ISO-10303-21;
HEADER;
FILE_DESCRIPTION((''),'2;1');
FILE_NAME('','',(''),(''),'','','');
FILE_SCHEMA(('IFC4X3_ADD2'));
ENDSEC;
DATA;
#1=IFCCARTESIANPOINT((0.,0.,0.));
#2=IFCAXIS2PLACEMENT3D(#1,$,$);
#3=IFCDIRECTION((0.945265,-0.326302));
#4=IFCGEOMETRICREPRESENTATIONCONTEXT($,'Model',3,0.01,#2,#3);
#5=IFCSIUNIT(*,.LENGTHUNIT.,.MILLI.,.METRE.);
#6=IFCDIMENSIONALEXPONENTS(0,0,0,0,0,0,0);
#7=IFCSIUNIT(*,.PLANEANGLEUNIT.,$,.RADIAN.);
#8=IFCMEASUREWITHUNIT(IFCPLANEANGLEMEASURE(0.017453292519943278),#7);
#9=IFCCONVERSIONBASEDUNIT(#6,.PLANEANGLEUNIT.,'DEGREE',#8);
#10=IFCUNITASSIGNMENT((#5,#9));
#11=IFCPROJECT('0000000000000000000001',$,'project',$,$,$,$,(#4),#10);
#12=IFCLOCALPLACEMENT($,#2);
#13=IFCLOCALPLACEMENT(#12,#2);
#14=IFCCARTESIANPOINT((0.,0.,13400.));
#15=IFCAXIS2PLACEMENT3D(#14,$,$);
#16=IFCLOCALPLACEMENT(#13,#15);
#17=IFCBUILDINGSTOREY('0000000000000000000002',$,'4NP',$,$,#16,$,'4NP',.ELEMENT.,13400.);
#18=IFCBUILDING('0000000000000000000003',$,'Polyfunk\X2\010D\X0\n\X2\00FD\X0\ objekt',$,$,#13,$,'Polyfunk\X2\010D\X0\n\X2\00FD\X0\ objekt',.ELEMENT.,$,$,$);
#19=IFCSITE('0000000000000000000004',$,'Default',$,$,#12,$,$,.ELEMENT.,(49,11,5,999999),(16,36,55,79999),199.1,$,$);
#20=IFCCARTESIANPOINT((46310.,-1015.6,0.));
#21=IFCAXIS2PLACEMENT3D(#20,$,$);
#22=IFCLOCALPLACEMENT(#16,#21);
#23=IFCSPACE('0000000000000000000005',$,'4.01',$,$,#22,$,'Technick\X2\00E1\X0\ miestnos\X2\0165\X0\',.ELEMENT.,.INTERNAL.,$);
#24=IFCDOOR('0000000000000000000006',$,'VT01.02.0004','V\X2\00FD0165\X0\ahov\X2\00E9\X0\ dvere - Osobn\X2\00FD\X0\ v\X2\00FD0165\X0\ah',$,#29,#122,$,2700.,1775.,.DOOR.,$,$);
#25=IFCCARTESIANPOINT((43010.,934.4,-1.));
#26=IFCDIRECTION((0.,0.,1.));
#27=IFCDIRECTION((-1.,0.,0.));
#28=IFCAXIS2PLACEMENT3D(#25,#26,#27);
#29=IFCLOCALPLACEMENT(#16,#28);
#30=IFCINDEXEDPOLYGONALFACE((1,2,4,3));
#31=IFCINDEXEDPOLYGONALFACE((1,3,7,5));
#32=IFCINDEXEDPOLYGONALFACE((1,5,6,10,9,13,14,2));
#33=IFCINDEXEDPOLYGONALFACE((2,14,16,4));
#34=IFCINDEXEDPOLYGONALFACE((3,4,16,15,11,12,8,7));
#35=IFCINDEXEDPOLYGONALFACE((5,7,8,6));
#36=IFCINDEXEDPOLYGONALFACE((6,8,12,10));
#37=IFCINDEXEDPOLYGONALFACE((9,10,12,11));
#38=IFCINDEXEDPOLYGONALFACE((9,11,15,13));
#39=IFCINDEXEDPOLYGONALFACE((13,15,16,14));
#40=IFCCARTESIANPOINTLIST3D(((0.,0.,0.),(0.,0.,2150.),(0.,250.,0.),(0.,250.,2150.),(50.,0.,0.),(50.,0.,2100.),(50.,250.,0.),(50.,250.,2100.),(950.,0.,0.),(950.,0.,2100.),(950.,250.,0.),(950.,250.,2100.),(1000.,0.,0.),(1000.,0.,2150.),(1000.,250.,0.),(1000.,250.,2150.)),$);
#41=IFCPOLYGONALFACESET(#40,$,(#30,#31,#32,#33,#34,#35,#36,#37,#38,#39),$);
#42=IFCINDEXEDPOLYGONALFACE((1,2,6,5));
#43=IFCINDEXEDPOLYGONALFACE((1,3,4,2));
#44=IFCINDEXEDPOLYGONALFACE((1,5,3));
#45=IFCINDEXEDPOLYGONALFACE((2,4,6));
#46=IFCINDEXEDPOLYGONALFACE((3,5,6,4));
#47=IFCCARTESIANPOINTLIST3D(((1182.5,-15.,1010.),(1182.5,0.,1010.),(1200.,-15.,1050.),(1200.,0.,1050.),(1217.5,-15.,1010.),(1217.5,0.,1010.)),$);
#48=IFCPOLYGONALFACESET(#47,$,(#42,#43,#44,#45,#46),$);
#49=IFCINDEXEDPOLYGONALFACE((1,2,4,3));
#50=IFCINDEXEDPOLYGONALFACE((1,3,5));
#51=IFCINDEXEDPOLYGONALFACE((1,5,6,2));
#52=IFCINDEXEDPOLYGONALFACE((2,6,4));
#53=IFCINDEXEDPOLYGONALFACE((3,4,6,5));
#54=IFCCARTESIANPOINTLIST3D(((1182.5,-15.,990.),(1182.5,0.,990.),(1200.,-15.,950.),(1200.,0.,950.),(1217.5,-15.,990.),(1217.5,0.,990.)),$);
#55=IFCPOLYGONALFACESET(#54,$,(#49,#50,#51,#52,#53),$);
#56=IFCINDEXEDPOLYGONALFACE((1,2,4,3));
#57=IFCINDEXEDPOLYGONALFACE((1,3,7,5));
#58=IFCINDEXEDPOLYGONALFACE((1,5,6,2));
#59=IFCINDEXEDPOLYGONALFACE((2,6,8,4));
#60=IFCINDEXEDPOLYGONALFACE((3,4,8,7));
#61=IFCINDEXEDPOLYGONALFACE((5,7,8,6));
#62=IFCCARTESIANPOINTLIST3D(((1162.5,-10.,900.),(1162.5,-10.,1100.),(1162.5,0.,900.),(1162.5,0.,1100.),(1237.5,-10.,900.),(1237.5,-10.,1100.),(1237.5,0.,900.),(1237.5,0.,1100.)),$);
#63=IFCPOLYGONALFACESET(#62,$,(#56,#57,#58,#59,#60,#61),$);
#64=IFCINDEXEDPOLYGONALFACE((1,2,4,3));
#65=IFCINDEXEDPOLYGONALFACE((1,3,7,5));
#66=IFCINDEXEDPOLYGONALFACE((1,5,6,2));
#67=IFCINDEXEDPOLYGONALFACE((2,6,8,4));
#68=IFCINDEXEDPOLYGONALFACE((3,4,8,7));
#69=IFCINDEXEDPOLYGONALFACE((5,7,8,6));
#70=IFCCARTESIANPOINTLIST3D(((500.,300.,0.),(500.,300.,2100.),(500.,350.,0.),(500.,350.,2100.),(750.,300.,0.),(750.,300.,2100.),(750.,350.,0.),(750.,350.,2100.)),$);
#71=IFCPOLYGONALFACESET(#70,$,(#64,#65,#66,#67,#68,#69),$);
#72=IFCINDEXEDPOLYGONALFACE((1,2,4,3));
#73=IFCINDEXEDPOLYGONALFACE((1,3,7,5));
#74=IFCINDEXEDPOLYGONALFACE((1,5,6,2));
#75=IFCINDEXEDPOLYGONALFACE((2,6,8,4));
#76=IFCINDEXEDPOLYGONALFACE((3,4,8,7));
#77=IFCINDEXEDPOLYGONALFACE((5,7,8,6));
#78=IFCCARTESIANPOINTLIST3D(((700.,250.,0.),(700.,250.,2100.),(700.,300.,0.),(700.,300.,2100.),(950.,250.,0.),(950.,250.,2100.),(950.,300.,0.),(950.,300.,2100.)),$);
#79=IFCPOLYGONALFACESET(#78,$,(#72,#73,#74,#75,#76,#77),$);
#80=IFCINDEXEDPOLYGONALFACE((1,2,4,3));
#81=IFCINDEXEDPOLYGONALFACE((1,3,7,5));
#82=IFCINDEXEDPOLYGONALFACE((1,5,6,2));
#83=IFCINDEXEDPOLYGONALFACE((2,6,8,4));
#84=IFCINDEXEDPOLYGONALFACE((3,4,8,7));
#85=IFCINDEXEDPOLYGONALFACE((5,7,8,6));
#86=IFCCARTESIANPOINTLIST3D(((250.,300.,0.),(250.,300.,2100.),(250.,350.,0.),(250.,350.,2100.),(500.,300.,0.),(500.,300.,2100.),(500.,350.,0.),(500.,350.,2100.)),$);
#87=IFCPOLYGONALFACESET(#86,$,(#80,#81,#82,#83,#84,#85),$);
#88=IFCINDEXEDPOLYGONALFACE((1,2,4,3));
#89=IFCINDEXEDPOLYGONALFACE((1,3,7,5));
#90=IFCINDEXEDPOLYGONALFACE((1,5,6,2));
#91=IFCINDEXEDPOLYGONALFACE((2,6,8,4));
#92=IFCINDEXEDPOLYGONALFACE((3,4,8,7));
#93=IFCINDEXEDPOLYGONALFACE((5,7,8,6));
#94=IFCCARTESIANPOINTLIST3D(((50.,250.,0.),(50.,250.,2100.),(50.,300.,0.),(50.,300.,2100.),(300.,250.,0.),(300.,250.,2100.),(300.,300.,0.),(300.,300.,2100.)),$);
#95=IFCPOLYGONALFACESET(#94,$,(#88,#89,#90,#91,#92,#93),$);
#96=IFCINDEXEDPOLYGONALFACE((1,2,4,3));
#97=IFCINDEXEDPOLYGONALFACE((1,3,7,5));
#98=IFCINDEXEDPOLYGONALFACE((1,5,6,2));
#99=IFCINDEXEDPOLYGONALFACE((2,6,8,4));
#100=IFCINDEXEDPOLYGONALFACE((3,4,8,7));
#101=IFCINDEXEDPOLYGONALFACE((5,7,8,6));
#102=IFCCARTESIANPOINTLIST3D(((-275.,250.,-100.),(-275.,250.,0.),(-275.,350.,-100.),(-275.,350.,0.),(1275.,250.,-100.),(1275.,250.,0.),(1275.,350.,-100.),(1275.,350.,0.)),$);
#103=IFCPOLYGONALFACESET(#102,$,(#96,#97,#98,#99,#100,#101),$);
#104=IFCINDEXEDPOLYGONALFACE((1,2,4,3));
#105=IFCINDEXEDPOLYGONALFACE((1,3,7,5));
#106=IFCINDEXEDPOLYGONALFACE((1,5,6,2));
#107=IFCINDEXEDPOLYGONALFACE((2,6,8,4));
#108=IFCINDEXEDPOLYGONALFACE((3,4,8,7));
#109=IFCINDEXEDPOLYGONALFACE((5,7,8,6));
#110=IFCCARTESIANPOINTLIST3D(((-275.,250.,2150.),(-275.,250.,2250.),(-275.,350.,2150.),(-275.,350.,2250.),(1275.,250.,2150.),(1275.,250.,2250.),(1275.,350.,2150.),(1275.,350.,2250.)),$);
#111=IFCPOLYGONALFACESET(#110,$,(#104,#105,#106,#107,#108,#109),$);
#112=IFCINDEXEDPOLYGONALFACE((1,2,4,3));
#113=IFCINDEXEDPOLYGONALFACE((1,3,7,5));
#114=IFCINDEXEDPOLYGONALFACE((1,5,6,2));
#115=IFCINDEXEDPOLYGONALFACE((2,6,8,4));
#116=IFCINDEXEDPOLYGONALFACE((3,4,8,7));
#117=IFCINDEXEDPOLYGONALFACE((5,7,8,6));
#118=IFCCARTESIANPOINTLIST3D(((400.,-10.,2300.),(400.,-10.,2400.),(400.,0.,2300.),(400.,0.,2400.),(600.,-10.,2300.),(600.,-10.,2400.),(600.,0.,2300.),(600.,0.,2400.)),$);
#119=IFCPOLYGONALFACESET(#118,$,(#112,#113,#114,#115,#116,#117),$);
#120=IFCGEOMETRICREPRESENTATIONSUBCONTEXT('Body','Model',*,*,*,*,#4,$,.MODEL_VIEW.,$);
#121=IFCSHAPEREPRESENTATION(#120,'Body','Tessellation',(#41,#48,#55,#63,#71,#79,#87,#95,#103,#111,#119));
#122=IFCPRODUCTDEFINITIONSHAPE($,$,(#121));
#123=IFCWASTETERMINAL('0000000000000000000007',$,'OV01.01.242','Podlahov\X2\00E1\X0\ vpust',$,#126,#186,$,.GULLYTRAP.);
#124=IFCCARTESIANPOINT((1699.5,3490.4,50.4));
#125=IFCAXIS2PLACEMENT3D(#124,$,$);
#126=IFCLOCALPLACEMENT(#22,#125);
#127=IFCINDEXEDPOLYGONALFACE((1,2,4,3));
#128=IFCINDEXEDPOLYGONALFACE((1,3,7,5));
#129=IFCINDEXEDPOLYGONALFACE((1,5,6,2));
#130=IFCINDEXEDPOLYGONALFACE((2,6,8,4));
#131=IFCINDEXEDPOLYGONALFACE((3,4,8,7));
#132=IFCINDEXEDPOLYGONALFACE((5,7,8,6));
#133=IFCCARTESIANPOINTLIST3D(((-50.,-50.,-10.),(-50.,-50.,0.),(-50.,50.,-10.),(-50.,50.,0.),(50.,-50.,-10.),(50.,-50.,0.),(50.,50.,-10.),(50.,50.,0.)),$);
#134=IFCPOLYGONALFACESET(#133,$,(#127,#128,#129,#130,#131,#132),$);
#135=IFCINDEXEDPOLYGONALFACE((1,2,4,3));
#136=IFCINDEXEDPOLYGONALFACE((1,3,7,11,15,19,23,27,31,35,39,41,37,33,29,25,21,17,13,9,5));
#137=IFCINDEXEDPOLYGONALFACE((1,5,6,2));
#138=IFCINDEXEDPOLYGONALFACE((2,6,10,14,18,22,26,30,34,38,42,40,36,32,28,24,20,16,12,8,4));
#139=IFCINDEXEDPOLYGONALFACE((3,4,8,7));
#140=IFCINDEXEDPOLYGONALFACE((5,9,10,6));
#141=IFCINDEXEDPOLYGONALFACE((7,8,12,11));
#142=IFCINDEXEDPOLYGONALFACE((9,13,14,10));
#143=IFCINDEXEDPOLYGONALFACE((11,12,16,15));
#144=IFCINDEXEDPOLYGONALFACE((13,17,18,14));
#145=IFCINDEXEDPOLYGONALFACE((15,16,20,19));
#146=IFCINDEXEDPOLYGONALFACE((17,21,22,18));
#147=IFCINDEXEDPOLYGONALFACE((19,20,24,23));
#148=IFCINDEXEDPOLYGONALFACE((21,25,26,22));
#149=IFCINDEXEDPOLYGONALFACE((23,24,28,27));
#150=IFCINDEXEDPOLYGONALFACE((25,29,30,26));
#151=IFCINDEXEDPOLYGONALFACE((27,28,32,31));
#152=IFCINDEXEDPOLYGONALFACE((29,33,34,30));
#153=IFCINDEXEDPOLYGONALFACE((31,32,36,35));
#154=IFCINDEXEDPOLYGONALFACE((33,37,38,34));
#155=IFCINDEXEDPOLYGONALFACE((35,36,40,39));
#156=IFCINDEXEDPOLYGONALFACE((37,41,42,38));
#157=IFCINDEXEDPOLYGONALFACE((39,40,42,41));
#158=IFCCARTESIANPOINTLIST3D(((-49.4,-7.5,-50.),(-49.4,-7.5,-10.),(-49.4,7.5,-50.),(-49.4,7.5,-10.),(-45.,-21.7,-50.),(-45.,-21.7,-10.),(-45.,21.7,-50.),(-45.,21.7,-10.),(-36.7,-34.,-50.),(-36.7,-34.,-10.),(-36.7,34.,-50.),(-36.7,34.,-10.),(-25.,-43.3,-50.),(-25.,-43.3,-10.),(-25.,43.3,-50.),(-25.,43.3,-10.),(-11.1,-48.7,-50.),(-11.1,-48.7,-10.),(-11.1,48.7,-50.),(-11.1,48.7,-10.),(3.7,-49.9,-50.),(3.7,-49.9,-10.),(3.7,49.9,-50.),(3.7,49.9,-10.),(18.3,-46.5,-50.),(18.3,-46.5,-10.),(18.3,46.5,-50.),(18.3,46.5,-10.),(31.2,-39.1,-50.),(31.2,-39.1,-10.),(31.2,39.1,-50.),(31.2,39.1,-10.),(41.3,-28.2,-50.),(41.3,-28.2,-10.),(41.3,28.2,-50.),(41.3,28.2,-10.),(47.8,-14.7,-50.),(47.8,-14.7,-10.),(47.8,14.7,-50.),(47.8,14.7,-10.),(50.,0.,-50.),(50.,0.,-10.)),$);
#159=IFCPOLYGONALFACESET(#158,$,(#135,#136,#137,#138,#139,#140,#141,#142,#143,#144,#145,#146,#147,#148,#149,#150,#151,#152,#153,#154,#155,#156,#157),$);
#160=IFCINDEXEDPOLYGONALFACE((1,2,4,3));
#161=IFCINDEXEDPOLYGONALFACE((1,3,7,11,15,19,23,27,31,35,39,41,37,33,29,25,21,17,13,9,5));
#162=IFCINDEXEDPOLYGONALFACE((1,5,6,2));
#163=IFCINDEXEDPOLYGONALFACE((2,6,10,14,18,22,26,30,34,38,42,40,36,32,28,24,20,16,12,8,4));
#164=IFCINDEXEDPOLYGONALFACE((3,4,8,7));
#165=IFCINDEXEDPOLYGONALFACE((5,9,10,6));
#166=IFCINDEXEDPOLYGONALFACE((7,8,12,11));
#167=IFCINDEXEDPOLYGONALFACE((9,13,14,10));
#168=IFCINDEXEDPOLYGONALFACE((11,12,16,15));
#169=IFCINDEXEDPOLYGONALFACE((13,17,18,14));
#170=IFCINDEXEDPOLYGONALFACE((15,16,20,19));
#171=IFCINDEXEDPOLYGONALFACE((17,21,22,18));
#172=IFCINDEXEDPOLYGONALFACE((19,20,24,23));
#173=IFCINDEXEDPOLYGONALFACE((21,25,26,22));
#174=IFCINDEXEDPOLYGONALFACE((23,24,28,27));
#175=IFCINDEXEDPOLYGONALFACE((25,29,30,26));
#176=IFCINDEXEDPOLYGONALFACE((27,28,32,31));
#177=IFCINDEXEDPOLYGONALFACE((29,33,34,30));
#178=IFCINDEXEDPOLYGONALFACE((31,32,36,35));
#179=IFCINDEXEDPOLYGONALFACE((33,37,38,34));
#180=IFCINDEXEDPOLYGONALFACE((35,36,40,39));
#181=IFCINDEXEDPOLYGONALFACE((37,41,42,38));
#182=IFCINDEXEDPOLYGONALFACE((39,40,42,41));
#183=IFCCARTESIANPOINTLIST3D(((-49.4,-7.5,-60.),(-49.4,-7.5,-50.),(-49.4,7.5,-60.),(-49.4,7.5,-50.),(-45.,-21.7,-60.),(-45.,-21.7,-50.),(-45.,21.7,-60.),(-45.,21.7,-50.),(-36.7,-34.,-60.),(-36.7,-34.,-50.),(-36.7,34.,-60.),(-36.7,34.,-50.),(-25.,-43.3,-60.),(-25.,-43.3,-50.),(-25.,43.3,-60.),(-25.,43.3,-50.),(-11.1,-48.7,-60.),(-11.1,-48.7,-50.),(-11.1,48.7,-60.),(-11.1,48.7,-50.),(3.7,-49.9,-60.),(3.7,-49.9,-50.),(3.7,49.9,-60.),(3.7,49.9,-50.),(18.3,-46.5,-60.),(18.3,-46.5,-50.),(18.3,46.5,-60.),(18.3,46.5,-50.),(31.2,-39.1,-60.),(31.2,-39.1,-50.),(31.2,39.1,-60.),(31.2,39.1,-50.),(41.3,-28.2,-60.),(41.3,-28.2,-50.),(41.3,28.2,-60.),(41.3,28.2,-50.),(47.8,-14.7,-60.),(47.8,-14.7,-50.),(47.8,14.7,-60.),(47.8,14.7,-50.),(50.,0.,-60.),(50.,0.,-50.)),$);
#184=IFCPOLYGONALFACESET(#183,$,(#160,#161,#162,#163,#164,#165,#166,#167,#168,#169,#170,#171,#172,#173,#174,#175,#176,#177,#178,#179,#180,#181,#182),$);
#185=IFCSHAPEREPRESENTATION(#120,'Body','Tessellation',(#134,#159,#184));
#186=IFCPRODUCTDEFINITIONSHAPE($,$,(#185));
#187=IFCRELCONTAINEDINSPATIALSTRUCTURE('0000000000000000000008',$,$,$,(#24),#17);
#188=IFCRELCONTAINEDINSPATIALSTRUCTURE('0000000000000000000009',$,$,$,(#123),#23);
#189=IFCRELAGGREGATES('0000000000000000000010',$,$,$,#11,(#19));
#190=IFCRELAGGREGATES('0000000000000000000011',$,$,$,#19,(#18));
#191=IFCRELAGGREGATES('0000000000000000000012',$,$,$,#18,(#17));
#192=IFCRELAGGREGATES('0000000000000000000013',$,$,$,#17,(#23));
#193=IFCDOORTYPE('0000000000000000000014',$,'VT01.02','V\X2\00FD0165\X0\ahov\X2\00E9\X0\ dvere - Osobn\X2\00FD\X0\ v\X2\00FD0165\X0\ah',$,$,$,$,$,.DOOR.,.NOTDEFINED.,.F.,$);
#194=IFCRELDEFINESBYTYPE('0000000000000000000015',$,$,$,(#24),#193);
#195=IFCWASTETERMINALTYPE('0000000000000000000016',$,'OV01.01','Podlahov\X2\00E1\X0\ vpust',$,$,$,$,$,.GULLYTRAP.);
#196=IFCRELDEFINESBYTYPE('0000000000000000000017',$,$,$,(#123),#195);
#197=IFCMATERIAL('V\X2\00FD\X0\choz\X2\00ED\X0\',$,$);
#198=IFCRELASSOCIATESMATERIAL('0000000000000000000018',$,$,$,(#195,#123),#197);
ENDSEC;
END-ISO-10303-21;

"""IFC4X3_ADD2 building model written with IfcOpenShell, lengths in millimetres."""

from ifc_helpers import new_model, entity, si_unit, converted_unit, direction, frame, frame_2d, origin, origin_2d_with_axis, place, context, subcontext, project, spatial, polyline, rectangle, circle, outline, extrude, source, transform, mapped, material, type_object, type_shapes, element, save


model = new_model("IFC4X3_ADD2")

# Units and contexts
model_context = context("Model", 3, precision=0.01, world=origin(), true_north=direction((0.945265, -0.326302)))
body_context = subcontext(model_context, "Body", "Model", "MODEL_VIEW")
ifc_project = project(units=[si_unit("LENGTHUNIT", "METRE", prefix="MILLI"), converted_unit("PLANEANGLEUNIT", "DEGREE", entity("IfcPlaneAngleMeasure", 0.017453292519943278), si_unit("PLANEANGLEUNIT", "RADIAN"), dimensions=[0, 0, 0, 0, 0, 0, 0])], contexts=[model_context])

# Site, building, storey
site_placement = place(None, origin())
site = spatial("IfcSite", under=ifc_project, at=site_placement, Name="Default", CompositionType="ELEMENT", RefLatitude=(49, 11, 5, 999999), RefLongitude=(16, 36, 55, 79999), RefElevation=199.1)
building_placement = place(site_placement, origin())
building = spatial("IfcBuilding", under=site, at=building_placement, Name="Polyfunkčný objekt", LongName="Polyfunkčný objekt", CompositionType="ELEMENT")
storey_placement = place(building_placement, frame((0.0, 0.0, 13400.0)))
storey = spatial("IfcBuildingStorey", under=building, at=storey_placement, Name="4NP", LongName="4NP", CompositionType="ELEMENT", Elevation=13400.0)

# Door
door_type_1 = type_object("IfcDoorType", Name="VT01.02", Description="Výťahové dvere - Osobný výťah", OperationType="NOTDEFINED", ParameterTakesPrecedence=False, PredefinedType="DOOR")
shared_shape_1 = source(origin(), body_context, "Body", "SweptSolid", [
    extrude(outline(polyline([(-1087.5, -500.0), (1062.5, -500.0), (1062.5, -450.0), (-1037.5, -450.0), (-1037.5, 450.0), (1062.5, 450.0), (1062.5, 500.0), (-1087.5, 500.0), (-1087.5, -500.0)])), frame((500.0, 0.0, 1062.5), z_axis=(0.0, 1.0, 0.0), x_axis=(0.0, 0.0, -1.0)), (0.0, 0.0, 1.0), 250.0),
    extrude(outline(polyline([(-24.4, -10.7), (19.2, -10.7), (5.2, 21.4), (-24.4, -10.7)])), frame((1200.0, -15.0, 1023.3), z_axis=(0.0, 1.0, 0.0), x_axis=(0.400819, 0.0, -0.916157)), (0.0, 0.0, 1.0), 15.0),
    extrude(outline(polyline([(-24.4, -10.7), (19.2, -10.7), (5.2, 21.4), (-24.4, -10.7)])), frame((1200.0, -15.0, 976.7), z_axis=(0.0, 1.0, 0.0), x_axis=(-0.400819, 0.0, 0.916157)), (0.0, 0.0, 1.0), 15.0),
    extrude(rectangle(XDim=10.0, YDim=75.0, at=frame_2d((0.0, 0.0), x_axis=(1.0, 0.0))), frame((1200.0, -5.0, 900.0), z_axis=(0.0, 0.0, 1.0), x_axis=(0.0, 1.0, 0.0)), (0.0, 0.0, 1.0), 200.0),
    extrude(rectangle(XDim=50.0, YDim=250.0, at=origin_2d_with_axis()), frame((625.0, 325.0, 0.0), z_axis=(0.0, 0.0, 1.0), x_axis=(0.0, -1.0, 0.0)), (0.0, 0.0, 1.0), 2100.0),
    extrude(rectangle(XDim=50.0, YDim=250.0, at=frame_2d((0.0, 0.0), x_axis=(1.0, 0.0))), frame((825.0, 275.0, 0.0), z_axis=(0.0, 0.0, 1.0), x_axis=(0.0, -1.0, 0.0)), (0.0, 0.0, 1.0), 2100.0),
    extrude(rectangle(XDim=250.0, YDim=50.0, at=frame_2d((0.0, 0.0), x_axis=(1.0, 0.0))), frame((375.0, 325.0, 0.0), z_axis=(0.0, 0.0, 1.0), x_axis=(-1.0, 0.0, 0.0)), (0.0, 0.0, 1.0), 2100.0),
    extrude(rectangle(XDim=250.0, YDim=50.0, at=frame_2d((0.0, 0.0), x_axis=(1.0, 0.0))), frame((175.0, 275.0, 0.0), z_axis=(0.0, 0.0, 1.0), x_axis=(-1.0, 0.0, 0.0)), (0.0, 0.0, 1.0), 2100.0),
    extrude(rectangle(XDim=1550.0, YDim=100.0, at=frame_2d((0.0, 0.0), x_axis=(1.0, 0.0))), frame((500.0, 300.0, -100.0), z_axis=(0.0, 0.0, 1.0), x_axis=(-1.0, 0.0, 0.0)), (0.0, 0.0, 1.0), 100.0),
    extrude(rectangle(XDim=1550.0, YDim=100.0, at=frame_2d((0.0, 0.0), x_axis=(1.0, 0.0))), frame((500.0, 300.0, 2150.0), z_axis=(0.0, 0.0, 1.0), x_axis=(-1.0, 0.0, 0.0)), (0.0, 0.0, 1.0), 100.0),
    extrude(rectangle(XDim=10.0, YDim=200.0, at=frame_2d((0.0, 0.0), x_axis=(1.0, 0.0))), frame((500.0, -5.0, 2300.0), z_axis=(0.0, 0.0, 1.0), x_axis=(0.0, 1.0, 0.0)), (0.0, 0.0, 1.0), 100.0),
])
type_shapes(door_type_1, [shared_shape_1])
door_1_placement = place(storey_placement, frame((43010.0, 934.4, -1.0), z_axis=(0.0, 0.0, 1.0), x_axis=(-1.0, 0.0, 0.0)))
element("IfcDoor", 1, at=door_1_placement, inside=storey, type_object=door_type_1, Name="VT01.02.0004", Description="Výťahové dvere - Osobný výťah", OverallHeight=2700.0, OverallWidth=1775.0, PredefinedType="DOOR", context=body_context, shape_type="MappedRepresentation", body=[
    mapped(shared_shape_1, transform((0.0, 0.0, 0.0), scale=1.0)),
])

# Shared definitions
space_placement = place(storey_placement, frame((46310.0, -1015.6, 0.0)))
space = spatial("IfcSpace", under=storey, at=space_placement, Name="4.01", LongName="Technická miestnosť", CompositionType="ELEMENT", PredefinedType="INTERNAL")

# Waste terminal
ifc_material_1 = material(Name="Výchozí")
waste_terminal_type = type_object("IfcWasteTerminalType", Name="OV01.01", Description="Podlahová vpust", PredefinedType="GULLYTRAP", material=ifc_material_1)
shared_shape_2 = source(origin(), body_context, "Body", "SweptSolid", [
    extrude(rectangle(XDim=100.0, YDim=100.0, at=frame_2d((0.0, 0.0), x_axis=(1.0, 0.0))), frame((0.0, 0.0, -10.0), z_axis=(0.0, 0.0, 1.0), x_axis=(-1.0, 0.0, 0.0)), (0.0, 0.0, 1.0), 10.0),
    extrude(circle(Radius=50.0, at=frame_2d((0.0, 0.0), x_axis=(1.0, 0.0))), frame((0.0, 0.0, -50.0)), (0.0, 0.0, 1.0), 40.0),
    extrude(circle(Radius=50.0, at=frame_2d((0.0, 0.0), x_axis=(1.0, 0.0))), frame((0.0, 0.0, -60.0)), (0.0, 0.0, 1.0), 10.0),
])
type_shapes(waste_terminal_type, [shared_shape_2])
waste_terminal_placement = place(space_placement, frame((1699.5, 3490.4, 50.4)))
element("IfcWasteTerminal", 2, at=waste_terminal_placement, inside=space, type_object=waste_terminal_type, material=ifc_material_1, Name="OV01.01.242", Description="Podlahová vpust", PredefinedType="GULLYTRAP", context=body_context, shape_type="MappedRepresentation", body=[
    mapped(shared_shape_2, transform((0.0, 0.0, 0.0), scale=1.0)),
])

save(model, "model.ifc")
